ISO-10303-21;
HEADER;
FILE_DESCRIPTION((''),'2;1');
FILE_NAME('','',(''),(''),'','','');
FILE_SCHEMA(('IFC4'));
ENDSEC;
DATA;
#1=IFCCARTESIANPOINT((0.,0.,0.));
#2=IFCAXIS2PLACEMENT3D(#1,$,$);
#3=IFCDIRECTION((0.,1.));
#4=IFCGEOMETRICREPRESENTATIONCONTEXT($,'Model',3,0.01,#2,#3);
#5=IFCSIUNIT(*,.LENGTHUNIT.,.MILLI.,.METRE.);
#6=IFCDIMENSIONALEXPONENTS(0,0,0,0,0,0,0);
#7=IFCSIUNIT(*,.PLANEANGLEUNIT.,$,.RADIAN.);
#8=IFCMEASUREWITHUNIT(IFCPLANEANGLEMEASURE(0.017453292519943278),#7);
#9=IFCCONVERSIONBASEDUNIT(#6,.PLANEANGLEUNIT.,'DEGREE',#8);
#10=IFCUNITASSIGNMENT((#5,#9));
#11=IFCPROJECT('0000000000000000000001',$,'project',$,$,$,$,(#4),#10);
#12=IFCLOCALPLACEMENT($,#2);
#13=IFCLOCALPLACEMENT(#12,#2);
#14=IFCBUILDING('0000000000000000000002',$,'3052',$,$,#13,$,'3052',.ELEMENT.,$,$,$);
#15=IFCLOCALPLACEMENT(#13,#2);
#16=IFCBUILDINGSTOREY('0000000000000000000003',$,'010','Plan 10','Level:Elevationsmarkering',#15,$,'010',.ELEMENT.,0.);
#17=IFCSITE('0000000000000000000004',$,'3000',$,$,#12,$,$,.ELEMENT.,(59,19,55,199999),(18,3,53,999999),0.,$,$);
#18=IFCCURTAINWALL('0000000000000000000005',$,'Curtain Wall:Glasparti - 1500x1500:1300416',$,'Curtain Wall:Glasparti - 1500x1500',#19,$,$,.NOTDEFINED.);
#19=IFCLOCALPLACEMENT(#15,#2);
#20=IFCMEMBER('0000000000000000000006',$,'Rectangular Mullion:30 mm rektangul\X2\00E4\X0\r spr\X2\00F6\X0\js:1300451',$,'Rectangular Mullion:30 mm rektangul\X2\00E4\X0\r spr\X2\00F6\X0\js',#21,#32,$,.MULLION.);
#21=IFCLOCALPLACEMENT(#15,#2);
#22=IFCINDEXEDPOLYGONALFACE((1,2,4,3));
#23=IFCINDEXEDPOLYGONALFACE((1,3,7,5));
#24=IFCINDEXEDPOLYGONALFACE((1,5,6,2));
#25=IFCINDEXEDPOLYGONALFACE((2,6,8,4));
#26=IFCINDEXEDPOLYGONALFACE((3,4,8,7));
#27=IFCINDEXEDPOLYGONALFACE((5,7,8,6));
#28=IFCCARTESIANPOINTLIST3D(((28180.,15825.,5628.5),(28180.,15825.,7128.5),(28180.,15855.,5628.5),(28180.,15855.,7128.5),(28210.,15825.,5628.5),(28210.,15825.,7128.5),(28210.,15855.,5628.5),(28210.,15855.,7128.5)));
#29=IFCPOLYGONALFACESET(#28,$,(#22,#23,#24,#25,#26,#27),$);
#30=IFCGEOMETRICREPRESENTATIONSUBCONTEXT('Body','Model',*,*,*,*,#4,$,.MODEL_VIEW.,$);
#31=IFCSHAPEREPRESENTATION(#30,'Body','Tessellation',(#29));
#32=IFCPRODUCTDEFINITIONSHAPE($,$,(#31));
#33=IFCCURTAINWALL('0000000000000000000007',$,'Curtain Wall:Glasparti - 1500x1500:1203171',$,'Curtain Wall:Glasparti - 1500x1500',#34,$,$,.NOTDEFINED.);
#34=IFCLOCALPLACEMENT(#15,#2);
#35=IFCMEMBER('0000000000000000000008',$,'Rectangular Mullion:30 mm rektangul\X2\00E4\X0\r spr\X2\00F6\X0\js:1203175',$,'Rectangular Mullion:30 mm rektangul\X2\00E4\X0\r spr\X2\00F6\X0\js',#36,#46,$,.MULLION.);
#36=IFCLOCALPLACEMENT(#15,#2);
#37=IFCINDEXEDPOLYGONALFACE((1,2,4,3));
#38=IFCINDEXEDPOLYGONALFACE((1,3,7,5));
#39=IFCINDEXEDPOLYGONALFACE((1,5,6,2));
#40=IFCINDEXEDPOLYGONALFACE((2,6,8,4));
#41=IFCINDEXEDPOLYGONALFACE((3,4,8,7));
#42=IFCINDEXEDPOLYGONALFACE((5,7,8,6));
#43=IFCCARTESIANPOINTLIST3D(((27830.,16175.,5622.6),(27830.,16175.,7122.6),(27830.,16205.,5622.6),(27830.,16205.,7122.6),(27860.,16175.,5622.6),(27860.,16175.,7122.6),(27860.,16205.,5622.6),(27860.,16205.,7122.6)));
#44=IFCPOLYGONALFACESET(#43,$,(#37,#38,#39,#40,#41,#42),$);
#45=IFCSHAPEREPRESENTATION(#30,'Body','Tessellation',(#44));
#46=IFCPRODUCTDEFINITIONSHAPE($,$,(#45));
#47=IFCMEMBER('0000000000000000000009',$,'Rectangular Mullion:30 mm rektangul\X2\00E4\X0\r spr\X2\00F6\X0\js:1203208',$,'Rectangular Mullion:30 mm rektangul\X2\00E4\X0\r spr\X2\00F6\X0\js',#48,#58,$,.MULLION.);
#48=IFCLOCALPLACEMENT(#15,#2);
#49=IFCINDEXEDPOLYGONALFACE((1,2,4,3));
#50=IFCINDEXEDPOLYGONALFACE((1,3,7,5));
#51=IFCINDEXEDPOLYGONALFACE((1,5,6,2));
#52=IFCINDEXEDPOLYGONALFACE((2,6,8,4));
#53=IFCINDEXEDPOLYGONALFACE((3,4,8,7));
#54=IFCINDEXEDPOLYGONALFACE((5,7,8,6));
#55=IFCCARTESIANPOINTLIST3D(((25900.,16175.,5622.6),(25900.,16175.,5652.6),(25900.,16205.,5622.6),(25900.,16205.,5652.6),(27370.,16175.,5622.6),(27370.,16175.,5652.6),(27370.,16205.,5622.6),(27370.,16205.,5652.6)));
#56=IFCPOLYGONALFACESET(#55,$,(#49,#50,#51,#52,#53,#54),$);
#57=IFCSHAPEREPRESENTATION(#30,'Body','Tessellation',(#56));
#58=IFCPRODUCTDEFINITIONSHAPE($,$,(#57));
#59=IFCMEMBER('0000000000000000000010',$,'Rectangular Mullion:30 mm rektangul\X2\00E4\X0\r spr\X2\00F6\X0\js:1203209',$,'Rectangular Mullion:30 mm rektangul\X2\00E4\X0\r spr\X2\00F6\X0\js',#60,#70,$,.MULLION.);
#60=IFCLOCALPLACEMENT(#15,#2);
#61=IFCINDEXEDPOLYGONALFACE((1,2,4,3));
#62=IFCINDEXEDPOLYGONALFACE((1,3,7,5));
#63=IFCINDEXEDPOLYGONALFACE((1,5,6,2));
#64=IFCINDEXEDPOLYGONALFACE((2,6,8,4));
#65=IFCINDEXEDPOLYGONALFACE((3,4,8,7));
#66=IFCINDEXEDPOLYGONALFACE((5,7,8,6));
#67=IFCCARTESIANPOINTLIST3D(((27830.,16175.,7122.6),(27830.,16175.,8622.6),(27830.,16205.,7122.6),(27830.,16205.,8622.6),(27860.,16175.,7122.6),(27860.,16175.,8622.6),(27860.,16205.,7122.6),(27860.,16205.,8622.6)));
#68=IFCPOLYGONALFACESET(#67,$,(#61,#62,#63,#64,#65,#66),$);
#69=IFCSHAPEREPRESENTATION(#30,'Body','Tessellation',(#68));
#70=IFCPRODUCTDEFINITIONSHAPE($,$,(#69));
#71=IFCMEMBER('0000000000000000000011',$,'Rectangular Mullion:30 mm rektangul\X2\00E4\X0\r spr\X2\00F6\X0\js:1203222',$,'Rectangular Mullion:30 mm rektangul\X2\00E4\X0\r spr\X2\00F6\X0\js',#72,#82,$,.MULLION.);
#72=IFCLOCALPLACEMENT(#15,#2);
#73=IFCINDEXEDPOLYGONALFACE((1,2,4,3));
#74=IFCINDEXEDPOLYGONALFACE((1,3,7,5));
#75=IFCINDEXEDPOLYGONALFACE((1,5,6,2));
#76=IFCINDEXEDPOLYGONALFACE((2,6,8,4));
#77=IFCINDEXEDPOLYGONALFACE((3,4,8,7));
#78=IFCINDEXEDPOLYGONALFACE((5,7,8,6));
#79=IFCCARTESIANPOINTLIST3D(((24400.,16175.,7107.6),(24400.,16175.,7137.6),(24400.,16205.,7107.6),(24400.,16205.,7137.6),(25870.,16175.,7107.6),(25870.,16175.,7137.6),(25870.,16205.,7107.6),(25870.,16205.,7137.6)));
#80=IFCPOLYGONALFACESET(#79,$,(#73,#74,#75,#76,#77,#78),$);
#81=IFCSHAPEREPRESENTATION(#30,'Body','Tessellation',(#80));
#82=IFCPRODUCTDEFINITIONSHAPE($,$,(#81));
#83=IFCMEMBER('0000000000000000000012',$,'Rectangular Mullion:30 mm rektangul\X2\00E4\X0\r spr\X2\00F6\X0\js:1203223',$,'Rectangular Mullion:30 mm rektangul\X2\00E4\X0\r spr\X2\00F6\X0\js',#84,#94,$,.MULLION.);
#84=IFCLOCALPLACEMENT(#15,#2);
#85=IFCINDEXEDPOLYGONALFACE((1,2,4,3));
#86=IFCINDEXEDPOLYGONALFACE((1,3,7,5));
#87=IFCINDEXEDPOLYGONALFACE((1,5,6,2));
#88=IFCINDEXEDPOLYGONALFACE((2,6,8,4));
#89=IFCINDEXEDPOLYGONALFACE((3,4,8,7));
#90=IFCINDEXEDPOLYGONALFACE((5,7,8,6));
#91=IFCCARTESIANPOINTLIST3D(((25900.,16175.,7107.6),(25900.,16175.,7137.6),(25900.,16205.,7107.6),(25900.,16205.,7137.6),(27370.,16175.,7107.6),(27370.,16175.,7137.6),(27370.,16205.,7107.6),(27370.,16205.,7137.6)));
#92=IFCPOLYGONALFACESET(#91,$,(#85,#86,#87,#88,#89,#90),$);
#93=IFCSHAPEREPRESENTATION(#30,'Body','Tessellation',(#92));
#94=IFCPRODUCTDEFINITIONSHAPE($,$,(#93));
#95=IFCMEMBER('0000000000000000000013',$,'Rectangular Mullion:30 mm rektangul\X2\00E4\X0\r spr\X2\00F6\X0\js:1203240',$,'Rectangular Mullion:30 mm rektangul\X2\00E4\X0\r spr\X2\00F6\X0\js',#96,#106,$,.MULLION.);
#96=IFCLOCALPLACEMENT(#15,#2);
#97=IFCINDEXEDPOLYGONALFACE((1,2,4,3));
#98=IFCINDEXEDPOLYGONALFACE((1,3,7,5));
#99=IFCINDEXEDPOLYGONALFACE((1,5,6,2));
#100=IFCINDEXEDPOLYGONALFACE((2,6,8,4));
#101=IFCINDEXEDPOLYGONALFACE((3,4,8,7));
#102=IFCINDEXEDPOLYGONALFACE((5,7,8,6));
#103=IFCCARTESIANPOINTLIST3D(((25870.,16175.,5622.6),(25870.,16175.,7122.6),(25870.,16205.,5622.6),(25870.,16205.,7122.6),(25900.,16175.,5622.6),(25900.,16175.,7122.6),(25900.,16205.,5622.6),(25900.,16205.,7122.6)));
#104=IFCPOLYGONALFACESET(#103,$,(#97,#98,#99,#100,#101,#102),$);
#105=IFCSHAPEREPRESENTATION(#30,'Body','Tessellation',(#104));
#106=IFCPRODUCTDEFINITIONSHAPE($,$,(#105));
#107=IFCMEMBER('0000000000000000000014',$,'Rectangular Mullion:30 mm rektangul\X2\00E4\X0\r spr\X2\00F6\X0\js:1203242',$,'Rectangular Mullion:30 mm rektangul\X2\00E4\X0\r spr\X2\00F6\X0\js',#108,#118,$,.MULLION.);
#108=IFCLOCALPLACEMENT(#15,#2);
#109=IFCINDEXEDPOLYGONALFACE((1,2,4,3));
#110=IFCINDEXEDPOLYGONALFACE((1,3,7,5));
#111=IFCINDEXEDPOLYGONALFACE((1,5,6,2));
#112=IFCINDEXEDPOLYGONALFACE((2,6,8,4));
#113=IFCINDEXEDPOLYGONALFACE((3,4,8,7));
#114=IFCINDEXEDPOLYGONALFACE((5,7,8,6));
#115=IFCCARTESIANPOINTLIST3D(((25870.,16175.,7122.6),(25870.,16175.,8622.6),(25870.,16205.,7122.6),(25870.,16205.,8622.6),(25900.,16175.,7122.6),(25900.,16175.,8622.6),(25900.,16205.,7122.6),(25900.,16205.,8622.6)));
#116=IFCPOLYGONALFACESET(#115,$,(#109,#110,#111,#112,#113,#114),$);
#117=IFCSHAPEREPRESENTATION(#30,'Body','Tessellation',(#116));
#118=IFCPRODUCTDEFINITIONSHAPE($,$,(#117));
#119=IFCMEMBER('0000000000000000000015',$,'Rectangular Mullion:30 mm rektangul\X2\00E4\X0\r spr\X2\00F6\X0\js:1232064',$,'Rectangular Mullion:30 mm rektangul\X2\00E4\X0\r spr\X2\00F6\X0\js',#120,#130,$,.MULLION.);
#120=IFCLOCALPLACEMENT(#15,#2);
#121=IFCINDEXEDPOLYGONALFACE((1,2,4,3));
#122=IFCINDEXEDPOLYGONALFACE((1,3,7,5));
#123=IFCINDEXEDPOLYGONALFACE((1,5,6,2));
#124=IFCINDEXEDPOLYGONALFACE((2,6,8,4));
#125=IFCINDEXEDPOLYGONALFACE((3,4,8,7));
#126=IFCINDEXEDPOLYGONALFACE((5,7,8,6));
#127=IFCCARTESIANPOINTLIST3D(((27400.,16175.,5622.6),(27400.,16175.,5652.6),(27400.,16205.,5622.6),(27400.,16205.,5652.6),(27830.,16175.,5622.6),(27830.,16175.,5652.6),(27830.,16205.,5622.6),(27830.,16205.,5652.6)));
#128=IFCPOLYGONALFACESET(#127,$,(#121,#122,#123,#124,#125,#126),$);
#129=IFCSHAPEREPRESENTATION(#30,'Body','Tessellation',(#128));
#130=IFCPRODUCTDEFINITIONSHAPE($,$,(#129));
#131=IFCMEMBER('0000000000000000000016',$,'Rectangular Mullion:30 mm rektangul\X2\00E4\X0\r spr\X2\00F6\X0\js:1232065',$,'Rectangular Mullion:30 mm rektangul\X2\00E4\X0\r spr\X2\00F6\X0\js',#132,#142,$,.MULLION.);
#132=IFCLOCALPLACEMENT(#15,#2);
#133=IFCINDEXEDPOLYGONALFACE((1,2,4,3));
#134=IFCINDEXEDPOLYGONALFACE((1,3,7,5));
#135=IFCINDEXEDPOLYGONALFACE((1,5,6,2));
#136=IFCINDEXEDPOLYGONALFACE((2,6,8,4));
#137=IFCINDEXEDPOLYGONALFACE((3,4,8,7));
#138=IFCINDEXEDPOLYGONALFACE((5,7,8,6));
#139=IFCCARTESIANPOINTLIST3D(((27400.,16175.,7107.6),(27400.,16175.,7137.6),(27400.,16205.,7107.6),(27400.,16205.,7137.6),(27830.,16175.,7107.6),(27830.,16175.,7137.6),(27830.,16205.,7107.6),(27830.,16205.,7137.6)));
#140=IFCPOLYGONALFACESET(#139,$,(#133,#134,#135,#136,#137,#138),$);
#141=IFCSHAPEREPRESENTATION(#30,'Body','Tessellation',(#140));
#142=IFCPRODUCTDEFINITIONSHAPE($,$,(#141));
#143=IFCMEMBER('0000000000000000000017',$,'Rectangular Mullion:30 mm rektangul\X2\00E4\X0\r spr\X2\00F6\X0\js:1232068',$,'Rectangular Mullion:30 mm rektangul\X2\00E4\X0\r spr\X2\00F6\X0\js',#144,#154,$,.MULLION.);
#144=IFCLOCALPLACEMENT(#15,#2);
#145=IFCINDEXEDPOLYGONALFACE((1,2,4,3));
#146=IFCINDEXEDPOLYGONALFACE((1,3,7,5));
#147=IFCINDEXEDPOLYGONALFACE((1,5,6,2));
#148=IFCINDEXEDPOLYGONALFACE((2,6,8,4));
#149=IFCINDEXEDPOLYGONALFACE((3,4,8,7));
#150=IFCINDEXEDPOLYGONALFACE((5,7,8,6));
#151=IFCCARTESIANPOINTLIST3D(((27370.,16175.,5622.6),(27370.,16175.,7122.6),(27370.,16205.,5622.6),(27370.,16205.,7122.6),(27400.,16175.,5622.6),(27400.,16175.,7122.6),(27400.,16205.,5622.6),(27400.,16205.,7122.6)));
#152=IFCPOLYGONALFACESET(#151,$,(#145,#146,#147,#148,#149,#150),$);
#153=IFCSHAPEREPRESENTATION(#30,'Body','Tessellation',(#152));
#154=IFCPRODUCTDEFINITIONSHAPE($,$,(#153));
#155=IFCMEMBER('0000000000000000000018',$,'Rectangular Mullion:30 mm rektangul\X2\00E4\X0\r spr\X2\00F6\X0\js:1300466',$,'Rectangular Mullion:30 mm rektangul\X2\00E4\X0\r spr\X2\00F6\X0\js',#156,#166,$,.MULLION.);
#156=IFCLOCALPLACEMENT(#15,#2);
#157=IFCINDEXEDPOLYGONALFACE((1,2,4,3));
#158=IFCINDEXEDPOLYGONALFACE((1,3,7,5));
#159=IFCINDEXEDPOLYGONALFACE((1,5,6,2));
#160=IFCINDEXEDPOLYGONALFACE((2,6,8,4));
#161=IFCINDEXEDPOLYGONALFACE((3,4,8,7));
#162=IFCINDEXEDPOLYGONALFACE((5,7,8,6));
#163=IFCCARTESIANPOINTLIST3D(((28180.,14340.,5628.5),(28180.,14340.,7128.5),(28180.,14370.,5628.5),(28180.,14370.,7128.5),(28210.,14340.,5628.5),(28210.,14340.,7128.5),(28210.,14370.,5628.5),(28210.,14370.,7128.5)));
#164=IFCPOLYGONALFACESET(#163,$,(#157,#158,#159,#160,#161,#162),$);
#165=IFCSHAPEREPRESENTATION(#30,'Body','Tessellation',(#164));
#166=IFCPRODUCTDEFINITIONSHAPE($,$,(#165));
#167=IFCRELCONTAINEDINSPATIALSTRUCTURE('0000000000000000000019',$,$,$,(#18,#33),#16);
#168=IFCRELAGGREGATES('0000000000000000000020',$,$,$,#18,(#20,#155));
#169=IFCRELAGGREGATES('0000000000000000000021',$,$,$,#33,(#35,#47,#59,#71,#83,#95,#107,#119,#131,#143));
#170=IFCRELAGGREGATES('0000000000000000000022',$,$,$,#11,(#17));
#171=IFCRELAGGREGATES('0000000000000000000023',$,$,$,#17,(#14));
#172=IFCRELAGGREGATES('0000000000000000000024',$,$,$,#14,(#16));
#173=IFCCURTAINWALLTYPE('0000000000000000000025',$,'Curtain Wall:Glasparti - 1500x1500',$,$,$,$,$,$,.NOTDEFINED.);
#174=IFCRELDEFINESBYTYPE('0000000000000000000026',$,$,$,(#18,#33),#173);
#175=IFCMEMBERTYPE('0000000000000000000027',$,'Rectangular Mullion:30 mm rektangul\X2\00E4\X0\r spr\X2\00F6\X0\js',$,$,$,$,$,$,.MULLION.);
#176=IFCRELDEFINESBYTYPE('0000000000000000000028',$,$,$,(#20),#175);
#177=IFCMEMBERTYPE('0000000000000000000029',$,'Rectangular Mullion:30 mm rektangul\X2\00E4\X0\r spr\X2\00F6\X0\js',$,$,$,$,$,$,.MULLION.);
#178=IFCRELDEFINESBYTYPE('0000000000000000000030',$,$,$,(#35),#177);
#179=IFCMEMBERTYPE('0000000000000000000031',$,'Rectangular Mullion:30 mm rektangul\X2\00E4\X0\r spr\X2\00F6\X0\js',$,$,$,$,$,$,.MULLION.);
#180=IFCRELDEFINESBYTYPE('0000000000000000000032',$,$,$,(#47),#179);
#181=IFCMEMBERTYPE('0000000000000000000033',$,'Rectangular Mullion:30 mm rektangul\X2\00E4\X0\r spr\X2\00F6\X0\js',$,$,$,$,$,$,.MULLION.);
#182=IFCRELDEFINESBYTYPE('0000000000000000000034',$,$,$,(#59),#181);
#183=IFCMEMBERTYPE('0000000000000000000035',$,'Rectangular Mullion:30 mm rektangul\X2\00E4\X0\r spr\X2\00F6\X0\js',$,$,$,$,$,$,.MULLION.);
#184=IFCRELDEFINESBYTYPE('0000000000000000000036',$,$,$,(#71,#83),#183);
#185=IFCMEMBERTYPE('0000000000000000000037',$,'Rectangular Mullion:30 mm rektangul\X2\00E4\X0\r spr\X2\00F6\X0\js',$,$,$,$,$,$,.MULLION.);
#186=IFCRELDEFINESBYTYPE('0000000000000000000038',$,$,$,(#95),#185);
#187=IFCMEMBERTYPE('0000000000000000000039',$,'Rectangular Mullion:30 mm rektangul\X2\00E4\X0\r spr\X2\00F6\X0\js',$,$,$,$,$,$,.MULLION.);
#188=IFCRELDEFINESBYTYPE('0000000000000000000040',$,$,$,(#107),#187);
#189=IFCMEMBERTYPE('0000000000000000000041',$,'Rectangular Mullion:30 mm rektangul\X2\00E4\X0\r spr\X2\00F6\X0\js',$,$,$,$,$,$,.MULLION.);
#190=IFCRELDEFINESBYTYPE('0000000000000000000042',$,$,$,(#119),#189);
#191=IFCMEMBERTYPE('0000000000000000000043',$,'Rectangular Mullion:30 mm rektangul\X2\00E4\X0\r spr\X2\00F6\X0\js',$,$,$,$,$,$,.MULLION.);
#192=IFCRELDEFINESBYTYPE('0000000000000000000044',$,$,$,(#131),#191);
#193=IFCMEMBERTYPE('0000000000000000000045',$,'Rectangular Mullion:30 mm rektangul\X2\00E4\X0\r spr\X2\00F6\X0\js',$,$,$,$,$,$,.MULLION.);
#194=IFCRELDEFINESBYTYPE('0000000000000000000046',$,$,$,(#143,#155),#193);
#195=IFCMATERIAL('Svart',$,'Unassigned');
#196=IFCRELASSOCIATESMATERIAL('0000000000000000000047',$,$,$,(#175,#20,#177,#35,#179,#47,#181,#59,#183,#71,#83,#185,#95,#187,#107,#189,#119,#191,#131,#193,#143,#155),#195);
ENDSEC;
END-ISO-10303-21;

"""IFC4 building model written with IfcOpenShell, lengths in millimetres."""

from ifc_helpers import new_model, entity, si_unit, converted_unit, direction, frame, origin, place, context, subcontext, project, spatial, indexed_curve, outline, extrude, source, transform, mapped, material, type_object, type_shapes, element, aggregate, save


model = new_model("IFC4")

# Units and contexts
model_context = context("Model", 3, precision=0.01, world=origin(), true_north=direction((0.0, 1.0)))
body_context = subcontext(model_context, "Body", "Model", "MODEL_VIEW")
ifc_project = project(units=[si_unit("LENGTHUNIT", "METRE", prefix="MILLI"), converted_unit("PLANEANGLEUNIT", "DEGREE", entity("IfcPlaneAngleMeasure", 0.017453292519943278), si_unit("PLANEANGLEUNIT", "RADIAN"), dimensions=[0, 0, 0, 0, 0, 0, 0])], contexts=[model_context])

# Site, building, storey
site_placement = place(None, origin())
site = spatial("IfcSite", under=ifc_project, at=site_placement, Name="3000", CompositionType="ELEMENT", RefLatitude=(59, 19, 55, 199999), RefLongitude=(18, 3, 53, 999999), RefElevation=0.0)
building_placement = place(site_placement, origin())
building = spatial("IfcBuilding", under=site, at=building_placement, Name="3052", LongName="3052", CompositionType="ELEMENT")
storey_placement = place(building_placement, origin())
storey = spatial("IfcBuildingStorey", under=building, at=storey_placement, Name="010", Description="Plan 10", ObjectType="Level:Elevationsmarkering", LongName="010", CompositionType="ELEMENT", Elevation=0.0)

# Curtain wall, member
curtain_wall_type = type_object("IfcCurtainWallType", Name="Curtain Wall:Glasparti - 1500x1500", PredefinedType="NOTDEFINED")
curtain_wall_1_placement = place(storey_placement, origin())
curtain_wall_1 = element("IfcCurtainWall", 1, at=curtain_wall_1_placement, inside=storey, type_object=curtain_wall_type, Name="Curtain Wall:Glasparti - 1500x1500:1300416", ObjectType="Curtain Wall:Glasparti - 1500x1500", PredefinedType="NOTDEFINED")
ifc_material_1 = material(Name="Svart", Category="Unassigned")
member_type_1 = type_object("IfcMemberType", Name="Rectangular Mullion:30 mm rektangulär spröjs", PredefinedType="MULLION", material=ifc_material_1)
shared_shape_1 = source(origin(), body_context, "Body", "SweptSolid", [
    extrude(outline(indexed_curve([(-15.0, -15.0), (15.0, -15.0), (15.0, 15.0), (-15.0, 15.0), (-15.0, -15.0)], self_intersect=False)), frame((-15.0, 0.0, -1500.0), z_axis=(0.0, 0.0, 1.0), x_axis=(-1.0, 0.0, 0.0)), (0.0, 0.0, 1.0), 1500.0),
])
type_shapes(member_type_1, [shared_shape_1])
member_1_placement = place(curtain_wall_1_placement, frame((28195.0, 15855.0, 7128.5), z_axis=(0.0, 0.0, 1.0), x_axis=(0.0, 1.0, 0.0)))
member_1 = element("IfcMember", 2, at=member_1_placement, type_object=member_type_1, material=ifc_material_1, Name="Rectangular Mullion:30 mm rektangulär spröjs:1300451", ObjectType="Rectangular Mullion:30 mm rektangulär spröjs", PredefinedType="MULLION", context=body_context, shape_type="MappedRepresentation", body=[
    mapped(shared_shape_1, transform((0.0, 0.0, 0.0), scale=1.0)),
])

# Curtain wall, members
curtain_wall_2_placement = place(storey_placement, origin())
curtain_wall_2 = element("IfcCurtainWall", 3, at=curtain_wall_2_placement, inside=storey, type_object=curtain_wall_type, Name="Curtain Wall:Glasparti - 1500x1500:1203171", ObjectType="Curtain Wall:Glasparti - 1500x1500", PredefinedType="NOTDEFINED")
member_type_2 = type_object("IfcMemberType", Name="Rectangular Mullion:30 mm rektangulär spröjs", PredefinedType="MULLION", material=ifc_material_1)
shared_shape_2 = source(origin(), body_context, "Body", "SweptSolid", [
    extrude(outline(indexed_curve([(-15.0, -15.0), (15.0, -15.0), (15.0, 15.0), (-15.0, 15.0), (-15.0, -15.0)], self_intersect=False)), frame((-15.0, 0.0, -1500.0), z_axis=(0.0, 0.0, 1.0), x_axis=(-1.0, 0.0, 0.0)), (0.0, 0.0, 1.0), 1500.0),
])
type_shapes(member_type_2, [shared_shape_2])
member_2_placement = place(curtain_wall_2_placement, frame((27860.0, 16190.0, 5622.6), z_axis=(0.0, 0.0, -1.0), x_axis=(1.0, 0.0, 0.0)))
member_2 = element("IfcMember", 4, at=member_2_placement, type_object=member_type_2, material=ifc_material_1, Name="Rectangular Mullion:30 mm rektangulär spröjs:1203175", ObjectType="Rectangular Mullion:30 mm rektangulär spröjs", PredefinedType="MULLION", context=body_context, shape_type="MappedRepresentation", body=[
    mapped(shared_shape_2, transform((0.0, 0.0, 0.0), scale=1.0)),
])
member_type_3 = type_object("IfcMemberType", Name="Rectangular Mullion:30 mm rektangulär spröjs", PredefinedType="MULLION", material=ifc_material_1)
shared_shape_3 = source(origin(), body_context, "Body", "SweptSolid", [
    extrude(outline(indexed_curve([(-15.0, -15.0), (15.0, -15.0), (15.0, 15.0), (-15.0, 15.0), (-15.0, -15.0)], self_intersect=False)), frame((-15.0, 0.0, -1470.0), z_axis=(0.0, 0.0, 1.0), x_axis=(-1.0, 0.0, 0.0)), (0.0, 0.0, 1.0), 1470.0),
])
type_shapes(member_type_3, [shared_shape_3])
member_3_placement = place(curtain_wall_2_placement, frame((25900.0, 16190.0, 5622.6), z_axis=(-1.0, 0.0, 0.0), x_axis=(0.0, 0.0, -1.0)))
member_3 = element("IfcMember", 5, at=member_3_placement, type_object=member_type_3, material=ifc_material_1, Name="Rectangular Mullion:30 mm rektangulär spröjs:1203208", ObjectType="Rectangular Mullion:30 mm rektangulär spröjs", PredefinedType="MULLION", context=body_context, shape_type="MappedRepresentation", body=[
    mapped(shared_shape_3, transform((0.0, 0.0, 0.0), scale=1.0)),
])
member_type_4 = type_object("IfcMemberType", Name="Rectangular Mullion:30 mm rektangulär spröjs", PredefinedType="MULLION", material=ifc_material_1)
shared_shape_4 = source(origin(), body_context, "Body", "SweptSolid", [
    extrude(outline(indexed_curve([(-15.0, -15.0), (15.0, -15.0), (15.0, 15.0), (-15.0, 15.0), (-15.0, -15.0)], self_intersect=False)), frame((-15.0, 0.0, -1500.0), z_axis=(0.0, 0.0, 1.0), x_axis=(-1.0, 0.0, 0.0)), (0.0, 0.0, 1.0), 1500.0),
])
type_shapes(member_type_4, [shared_shape_4])
member_4_placement = place(curtain_wall_2_placement, frame((27860.0, 16190.0, 7122.6), z_axis=(0.0, 0.0, -1.0), x_axis=(1.0, 0.0, 0.0)))
member_4 = element("IfcMember", 6, at=member_4_placement, type_object=member_type_4, material=ifc_material_1, Name="Rectangular Mullion:30 mm rektangulär spröjs:1203209", ObjectType="Rectangular Mullion:30 mm rektangulär spröjs", PredefinedType="MULLION", context=body_context, shape_type="MappedRepresentation", body=[
    mapped(shared_shape_4, transform((0.0, 0.0, 0.0), scale=1.0)),
])
member_type_5 = type_object("IfcMemberType", Name="Rectangular Mullion:30 mm rektangulär spröjs", PredefinedType="MULLION", material=ifc_material_1)
shared_shape_5 = source(origin(), body_context, "Body", "SweptSolid", [
    extrude(outline(indexed_curve([(-15.0, -15.0), (15.0, -15.0), (15.0, 15.0), (-15.0, 15.0), (-15.0, -15.0)], self_intersect=False)), frame((0.0, 0.0, -1470.0), z_axis=(0.0, 0.0, 1.0), x_axis=(-1.0, 0.0, 0.0)), (0.0, 0.0, 1.0), 1470.0),
])
type_shapes(member_type_5, [shared_shape_5])
member_5_placement = place(curtain_wall_2_placement, frame((25870.0, 16190.0, 7122.6), z_axis=(1.0, 0.0, 0.0), x_axis=(0.0, 0.0, 1.0)))
member_5 = element("IfcMember", 7, at=member_5_placement, type_object=member_type_5, material=ifc_material_1, Name="Rectangular Mullion:30 mm rektangulär spröjs:1203222", ObjectType="Rectangular Mullion:30 mm rektangulär spröjs", PredefinedType="MULLION", context=body_context, shape_type="MappedRepresentation", body=[
    mapped(shared_shape_5, transform((0.0, 0.0, 0.0), scale=1.0)),
])
member_6_placement = place(curtain_wall_2_placement, frame((27370.0, 16190.0, 7122.6), z_axis=(1.0, 0.0, 0.0), x_axis=(0.0, 0.0, 1.0)))
member_6 = element("IfcMember", 8, at=member_6_placement, type_object=member_type_5, material=ifc_material_1, Name="Rectangular Mullion:30 mm rektangulär spröjs:1203223", ObjectType="Rectangular Mullion:30 mm rektangulär spröjs", PredefinedType="MULLION", context=body_context, shape_type="MappedRepresentation", body=[
    mapped(shared_shape_5, transform((0.0, 0.0, 0.0), scale=1.0)),
])
member_type_6 = type_object("IfcMemberType", Name="Rectangular Mullion:30 mm rektangulär spröjs", PredefinedType="MULLION", material=ifc_material_1)
shared_shape_6 = source(origin(), body_context, "Body", "SweptSolid", [
    extrude(outline(indexed_curve([(-15.0, -15.0), (15.0, -15.0), (15.0, 15.0), (-15.0, 15.0), (-15.0, -15.0)], self_intersect=False)), frame((0.0, 0.0, -1500.0), z_axis=(0.0, 0.0, 1.0), x_axis=(-1.0, 0.0, 0.0)), (0.0, 0.0, 1.0), 1500.0),
])
type_shapes(member_type_6, [shared_shape_6])
member_7_placement = place(curtain_wall_2_placement, frame((25885.0, 16190.0, 5622.6), z_axis=(0.0, 0.0, -1.0), x_axis=(1.0, 0.0, 0.0)))
member_7 = element("IfcMember", 9, at=member_7_placement, type_object=member_type_6, material=ifc_material_1, Name="Rectangular Mullion:30 mm rektangulär spröjs:1203240", ObjectType="Rectangular Mullion:30 mm rektangulär spröjs", PredefinedType="MULLION", context=body_context, shape_type="MappedRepresentation", body=[
    mapped(shared_shape_6, transform((0.0, 0.0, 0.0), scale=1.0)),
])
member_type_7 = type_object("IfcMemberType", Name="Rectangular Mullion:30 mm rektangulär spröjs", PredefinedType="MULLION", material=ifc_material_1)
shared_shape_7 = source(origin(), body_context, "Body", "SweptSolid", [
    extrude(outline(indexed_curve([(-15.0, -15.0), (15.0, -15.0), (15.0, 15.0), (-15.0, 15.0), (-15.0, -15.0)], self_intersect=False)), frame((0.0, 0.0, -1500.0), z_axis=(0.0, 0.0, 1.0), x_axis=(-1.0, 0.0, 0.0)), (0.0, 0.0, 1.0), 1500.0),
])
type_shapes(member_type_7, [shared_shape_7])
member_8_placement = place(curtain_wall_2_placement, frame((25885.0, 16190.0, 7122.6), z_axis=(0.0, 0.0, -1.0), x_axis=(1.0, 0.0, 0.0)))
member_8 = element("IfcMember", 10, at=member_8_placement, type_object=member_type_7, material=ifc_material_1, Name="Rectangular Mullion:30 mm rektangulär spröjs:1203242", ObjectType="Rectangular Mullion:30 mm rektangulär spröjs", PredefinedType="MULLION", context=body_context, shape_type="MappedRepresentation", body=[
    mapped(shared_shape_7, transform((0.0, 0.0, 0.0), scale=1.0)),
])
member_type_8 = type_object("IfcMemberType", Name="Rectangular Mullion:30 mm rektangulär spröjs", PredefinedType="MULLION", material=ifc_material_1)
shared_shape_8 = source(origin(), body_context, "Body", "SweptSolid", [
    extrude(outline(indexed_curve([(-15.0, -15.0), (15.0, -15.0), (15.0, 15.0), (-15.0, 15.0), (-15.0, -15.0)], self_intersect=False)), frame((-15.0, 0.0, -430.0), z_axis=(0.0, 0.0, 1.0), x_axis=(-1.0, 0.0, 0.0)), (0.0, 0.0, 1.0), 430.0),
])
type_shapes(member_type_8, [shared_shape_8])
member_9_placement = place(curtain_wall_2_placement, frame((27400.0, 16190.0, 5622.6), z_axis=(-1.0, 0.0, 0.0), x_axis=(0.0, 0.0, -1.0)))
member_9 = element("IfcMember", 11, at=member_9_placement, type_object=member_type_8, material=ifc_material_1, Name="Rectangular Mullion:30 mm rektangulär spröjs:1232064", ObjectType="Rectangular Mullion:30 mm rektangulär spröjs", PredefinedType="MULLION", context=body_context, shape_type="MappedRepresentation", body=[
    mapped(shared_shape_8, transform((0.0, 0.0, 0.0), scale=1.0)),
])
member_type_9 = type_object("IfcMemberType", Name="Rectangular Mullion:30 mm rektangulär spröjs", PredefinedType="MULLION", material=ifc_material_1)
shared_shape_9 = source(origin(), body_context, "Body", "SweptSolid", [
    extrude(outline(indexed_curve([(-15.0, -15.0), (15.0, -15.0), (15.0, 15.0), (-15.0, 15.0), (-15.0, -15.0)], self_intersect=False)), frame((0.0, 0.0, -430.0), z_axis=(0.0, 0.0, 1.0), x_axis=(-1.0, 0.0, 0.0)), (0.0, 0.0, 1.0), 430.0),
])
type_shapes(member_type_9, [shared_shape_9])
member_10_placement = place(curtain_wall_2_placement, frame((27830.0, 16190.0, 7122.6), z_axis=(1.0, 0.0, 0.0), x_axis=(0.0, 0.0, 1.0)))
member_10 = element("IfcMember", 12, at=member_10_placement, type_object=member_type_9, material=ifc_material_1, Name="Rectangular Mullion:30 mm rektangulär spröjs:1232065", ObjectType="Rectangular Mullion:30 mm rektangulär spröjs", PredefinedType="MULLION", context=body_context, shape_type="MappedRepresentation", body=[
    mapped(shared_shape_9, transform((0.0, 0.0, 0.0), scale=1.0)),
])
member_type_10 = type_object("IfcMemberType", Name="Rectangular Mullion:30 mm rektangulär spröjs", PredefinedType="MULLION", material=ifc_material_1)
shared_shape_10 = source(origin(), body_context, "Body", "SweptSolid", [
    extrude(outline(indexed_curve([(-15.0, -15.0), (15.0, -15.0), (15.0, 15.0), (-15.0, 15.0), (-15.0, -15.0)], self_intersect=False)), frame((0.0, 0.0, -1500.0), z_axis=(0.0, 0.0, 1.0), x_axis=(-1.0, 0.0, 0.0)), (0.0, 0.0, 1.0), 1500.0),
])
type_shapes(member_type_10, [shared_shape_10])
member_11_placement = place(curtain_wall_2_placement, frame((27385.0, 16190.0, 5622.6), z_axis=(0.0, 0.0, -1.0), x_axis=(1.0, 0.0, 0.0)))
member_11 = element("IfcMember", 13, at=member_11_placement, type_object=member_type_10, material=ifc_material_1, Name="Rectangular Mullion:30 mm rektangulär spröjs:1232068", ObjectType="Rectangular Mullion:30 mm rektangulär spröjs", PredefinedType="MULLION", context=body_context, shape_type="MappedRepresentation", body=[
    mapped(shared_shape_10, transform((0.0, 0.0, 0.0), scale=1.0)),
])

# Member
member_12_placement = place(curtain_wall_1_placement, frame((28195.0, 14355.0, 5628.5), z_axis=(0.0, 0.0, -1.0), x_axis=(0.0, -1.0, 0.0)))
member_12 = element("IfcMember", 14, at=member_12_placement, type_object=member_type_10, material=ifc_material_1, Name="Rectangular Mullion:30 mm rektangulär spröjs:1300466", ObjectType="Rectangular Mullion:30 mm rektangulär spröjs", PredefinedType="MULLION", context=body_context, shape_type="MappedRepresentation", body=[
    mapped(shared_shape_10, transform((0.0, 0.0, 0.0), scale=1.0)),
])

aggregate(curtain_wall_1, [member_1, member_12])
aggregate(curtain_wall_2, [member_2, member_3, member_4, member_5, member_6, member_7, member_8, member_9, member_10, member_11])

save(model, "model.ifc")
